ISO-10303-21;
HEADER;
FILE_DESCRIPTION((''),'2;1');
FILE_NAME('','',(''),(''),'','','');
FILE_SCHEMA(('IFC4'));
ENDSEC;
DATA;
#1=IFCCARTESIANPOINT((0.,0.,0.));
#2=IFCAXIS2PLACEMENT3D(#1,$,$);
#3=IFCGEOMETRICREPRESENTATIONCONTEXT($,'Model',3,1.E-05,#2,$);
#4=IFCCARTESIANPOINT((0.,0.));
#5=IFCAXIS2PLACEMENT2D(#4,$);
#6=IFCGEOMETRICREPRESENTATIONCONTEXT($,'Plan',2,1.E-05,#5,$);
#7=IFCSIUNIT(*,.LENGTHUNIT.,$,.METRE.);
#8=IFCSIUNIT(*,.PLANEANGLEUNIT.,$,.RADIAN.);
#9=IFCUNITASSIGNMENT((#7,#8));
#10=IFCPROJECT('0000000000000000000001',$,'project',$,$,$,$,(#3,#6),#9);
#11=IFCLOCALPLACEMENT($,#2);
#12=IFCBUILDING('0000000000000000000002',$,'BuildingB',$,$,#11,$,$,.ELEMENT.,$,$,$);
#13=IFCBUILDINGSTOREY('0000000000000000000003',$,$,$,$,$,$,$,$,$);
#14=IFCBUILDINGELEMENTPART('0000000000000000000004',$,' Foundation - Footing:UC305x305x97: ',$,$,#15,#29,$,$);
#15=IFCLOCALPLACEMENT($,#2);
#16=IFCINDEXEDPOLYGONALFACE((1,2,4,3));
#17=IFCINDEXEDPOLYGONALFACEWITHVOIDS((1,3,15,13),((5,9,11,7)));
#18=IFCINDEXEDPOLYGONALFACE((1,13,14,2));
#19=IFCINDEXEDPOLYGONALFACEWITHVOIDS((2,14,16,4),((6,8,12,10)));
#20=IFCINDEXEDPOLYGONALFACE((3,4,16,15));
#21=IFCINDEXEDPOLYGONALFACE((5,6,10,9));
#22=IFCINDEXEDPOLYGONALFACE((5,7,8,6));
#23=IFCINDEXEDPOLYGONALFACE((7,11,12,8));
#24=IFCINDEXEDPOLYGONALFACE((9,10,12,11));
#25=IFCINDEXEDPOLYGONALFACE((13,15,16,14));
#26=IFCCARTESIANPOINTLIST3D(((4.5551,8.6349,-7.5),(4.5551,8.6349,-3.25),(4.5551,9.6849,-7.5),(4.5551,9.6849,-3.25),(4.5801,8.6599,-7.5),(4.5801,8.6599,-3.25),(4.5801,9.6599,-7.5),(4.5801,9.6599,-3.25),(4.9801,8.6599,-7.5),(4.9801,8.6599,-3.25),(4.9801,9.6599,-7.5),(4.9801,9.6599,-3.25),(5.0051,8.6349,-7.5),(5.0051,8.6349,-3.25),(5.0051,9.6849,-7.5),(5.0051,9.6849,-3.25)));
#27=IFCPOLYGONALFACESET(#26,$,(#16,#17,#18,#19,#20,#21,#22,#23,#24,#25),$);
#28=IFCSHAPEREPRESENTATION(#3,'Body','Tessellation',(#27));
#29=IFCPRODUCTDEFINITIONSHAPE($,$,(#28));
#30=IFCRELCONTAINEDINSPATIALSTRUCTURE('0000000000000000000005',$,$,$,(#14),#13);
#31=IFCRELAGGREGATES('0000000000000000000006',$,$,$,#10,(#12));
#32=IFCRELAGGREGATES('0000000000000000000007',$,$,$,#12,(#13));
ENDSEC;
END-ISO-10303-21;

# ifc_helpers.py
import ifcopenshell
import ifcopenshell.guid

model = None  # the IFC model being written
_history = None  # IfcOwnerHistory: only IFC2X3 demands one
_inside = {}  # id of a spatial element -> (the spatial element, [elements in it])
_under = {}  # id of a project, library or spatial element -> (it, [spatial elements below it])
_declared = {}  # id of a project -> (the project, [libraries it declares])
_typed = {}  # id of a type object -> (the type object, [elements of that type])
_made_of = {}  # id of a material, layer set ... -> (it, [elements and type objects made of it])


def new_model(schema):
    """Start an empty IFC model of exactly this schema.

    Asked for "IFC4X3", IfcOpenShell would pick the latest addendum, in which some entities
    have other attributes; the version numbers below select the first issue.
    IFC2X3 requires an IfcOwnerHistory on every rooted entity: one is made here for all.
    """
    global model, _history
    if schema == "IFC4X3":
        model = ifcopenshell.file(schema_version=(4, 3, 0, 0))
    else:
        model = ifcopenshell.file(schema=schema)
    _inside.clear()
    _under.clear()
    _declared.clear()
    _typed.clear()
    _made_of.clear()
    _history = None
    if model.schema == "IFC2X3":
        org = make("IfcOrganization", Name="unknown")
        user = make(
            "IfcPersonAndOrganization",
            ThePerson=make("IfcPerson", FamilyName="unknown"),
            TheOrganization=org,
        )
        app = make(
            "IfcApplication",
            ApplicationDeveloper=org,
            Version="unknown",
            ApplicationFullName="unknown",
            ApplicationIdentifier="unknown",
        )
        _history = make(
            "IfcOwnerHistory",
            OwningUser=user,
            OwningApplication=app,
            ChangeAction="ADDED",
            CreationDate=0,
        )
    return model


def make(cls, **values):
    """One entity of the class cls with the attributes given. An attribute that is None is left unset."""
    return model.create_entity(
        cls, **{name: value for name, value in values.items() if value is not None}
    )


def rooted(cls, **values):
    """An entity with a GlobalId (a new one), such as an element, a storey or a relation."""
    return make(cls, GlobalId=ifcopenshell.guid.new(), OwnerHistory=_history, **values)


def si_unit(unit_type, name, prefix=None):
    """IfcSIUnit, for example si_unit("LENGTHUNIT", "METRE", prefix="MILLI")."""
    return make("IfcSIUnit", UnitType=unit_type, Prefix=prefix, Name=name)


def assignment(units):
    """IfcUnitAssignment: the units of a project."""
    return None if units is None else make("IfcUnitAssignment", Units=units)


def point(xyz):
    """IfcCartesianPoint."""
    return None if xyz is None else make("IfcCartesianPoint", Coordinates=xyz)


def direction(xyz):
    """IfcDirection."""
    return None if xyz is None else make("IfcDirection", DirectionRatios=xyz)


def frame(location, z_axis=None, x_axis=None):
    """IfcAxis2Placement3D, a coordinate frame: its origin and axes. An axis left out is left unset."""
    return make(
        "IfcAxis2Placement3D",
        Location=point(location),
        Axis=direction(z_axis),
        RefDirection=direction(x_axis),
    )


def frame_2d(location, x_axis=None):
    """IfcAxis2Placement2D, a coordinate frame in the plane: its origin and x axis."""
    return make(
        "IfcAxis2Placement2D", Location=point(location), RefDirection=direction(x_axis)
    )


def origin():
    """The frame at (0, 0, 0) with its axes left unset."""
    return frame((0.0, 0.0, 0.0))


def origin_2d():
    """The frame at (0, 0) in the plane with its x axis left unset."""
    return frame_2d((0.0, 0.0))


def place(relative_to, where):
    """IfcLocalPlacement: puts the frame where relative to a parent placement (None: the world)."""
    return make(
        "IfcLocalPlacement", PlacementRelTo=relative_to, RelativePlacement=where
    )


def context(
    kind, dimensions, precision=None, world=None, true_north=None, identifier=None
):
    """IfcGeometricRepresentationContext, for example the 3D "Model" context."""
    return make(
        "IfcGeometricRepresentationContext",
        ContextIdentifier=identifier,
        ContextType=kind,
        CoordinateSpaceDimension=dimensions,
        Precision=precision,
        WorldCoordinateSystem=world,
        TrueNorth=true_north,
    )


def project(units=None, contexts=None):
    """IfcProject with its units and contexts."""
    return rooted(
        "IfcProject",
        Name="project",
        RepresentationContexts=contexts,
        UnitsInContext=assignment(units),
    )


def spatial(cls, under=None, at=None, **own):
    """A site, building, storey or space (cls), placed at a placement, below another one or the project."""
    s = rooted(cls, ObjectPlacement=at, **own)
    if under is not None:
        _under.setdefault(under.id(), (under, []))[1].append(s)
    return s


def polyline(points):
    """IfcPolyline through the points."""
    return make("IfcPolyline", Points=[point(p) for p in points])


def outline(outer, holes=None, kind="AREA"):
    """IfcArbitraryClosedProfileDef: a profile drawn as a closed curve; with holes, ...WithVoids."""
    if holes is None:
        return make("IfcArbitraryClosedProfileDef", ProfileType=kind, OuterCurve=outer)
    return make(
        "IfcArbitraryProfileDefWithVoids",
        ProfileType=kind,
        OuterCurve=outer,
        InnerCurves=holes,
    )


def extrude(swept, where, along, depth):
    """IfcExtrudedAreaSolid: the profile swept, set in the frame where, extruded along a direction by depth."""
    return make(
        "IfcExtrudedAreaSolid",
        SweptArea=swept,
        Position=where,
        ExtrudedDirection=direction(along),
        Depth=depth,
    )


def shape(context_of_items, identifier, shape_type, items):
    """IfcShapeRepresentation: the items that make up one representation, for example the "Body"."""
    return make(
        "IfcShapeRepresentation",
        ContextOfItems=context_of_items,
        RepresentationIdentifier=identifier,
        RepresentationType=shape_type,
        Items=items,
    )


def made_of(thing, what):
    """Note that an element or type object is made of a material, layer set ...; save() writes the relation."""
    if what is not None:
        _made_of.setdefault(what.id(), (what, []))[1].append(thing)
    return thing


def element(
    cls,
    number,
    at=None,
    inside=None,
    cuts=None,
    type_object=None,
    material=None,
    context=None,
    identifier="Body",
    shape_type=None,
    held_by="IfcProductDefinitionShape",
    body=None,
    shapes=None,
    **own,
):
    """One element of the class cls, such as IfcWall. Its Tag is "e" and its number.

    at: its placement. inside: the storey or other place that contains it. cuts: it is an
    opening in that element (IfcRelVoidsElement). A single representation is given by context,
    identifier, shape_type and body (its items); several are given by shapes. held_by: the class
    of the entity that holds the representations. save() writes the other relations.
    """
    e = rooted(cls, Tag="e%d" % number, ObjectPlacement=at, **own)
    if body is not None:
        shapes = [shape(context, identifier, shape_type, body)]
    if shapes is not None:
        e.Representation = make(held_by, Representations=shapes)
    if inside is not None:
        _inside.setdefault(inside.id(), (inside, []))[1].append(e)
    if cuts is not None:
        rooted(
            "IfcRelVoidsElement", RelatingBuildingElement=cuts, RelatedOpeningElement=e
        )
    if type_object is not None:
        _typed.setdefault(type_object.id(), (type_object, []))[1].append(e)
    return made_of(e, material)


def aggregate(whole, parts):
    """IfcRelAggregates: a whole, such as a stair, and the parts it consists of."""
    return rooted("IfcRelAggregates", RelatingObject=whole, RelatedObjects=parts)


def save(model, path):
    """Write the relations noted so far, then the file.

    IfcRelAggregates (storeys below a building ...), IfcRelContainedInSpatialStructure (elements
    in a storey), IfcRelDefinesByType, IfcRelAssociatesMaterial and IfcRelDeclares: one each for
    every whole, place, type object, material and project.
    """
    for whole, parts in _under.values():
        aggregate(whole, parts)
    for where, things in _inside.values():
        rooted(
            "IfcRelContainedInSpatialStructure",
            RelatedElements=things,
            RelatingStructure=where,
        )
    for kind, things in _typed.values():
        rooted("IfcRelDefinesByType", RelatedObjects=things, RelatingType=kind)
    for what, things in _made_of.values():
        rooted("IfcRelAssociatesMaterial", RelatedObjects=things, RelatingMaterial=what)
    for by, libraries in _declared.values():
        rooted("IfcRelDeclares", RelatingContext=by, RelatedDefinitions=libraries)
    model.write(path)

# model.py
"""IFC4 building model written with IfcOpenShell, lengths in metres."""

from ifc_helpers import new_model, si_unit, origin, origin_2d, place, context, project, spatial, polyline, outline, extrude, element, save


model = new_model("IFC4")

# Units and contexts
model_context = context("Model", 3, precision=1e-05, world=origin())
plan_context = context("Plan", 2, precision=1e-05, world=origin_2d())
ifc_project = project(units=[si_unit("LENGTHUNIT", "METRE"), si_unit("PLANEANGLEUNIT", "RADIAN")], contexts=[model_context, plan_context])

# Building, storey
building_placement = place(None, origin())
building = spatial("IfcBuilding", under=ifc_project, at=building_placement, Name="BuildingB", CompositionType="ELEMENT")
storey = spatial("IfcBuildingStorey", under=building)

# Building element part, opening
building_element_part_1 = element("IfcBuildingElementPart", 1, inside=storey, Name=" Foundation - Footing:UC305x305x97: ", context=model_context, shape_type="SweptSolid", body=[
    extrude(outline(polyline([(4.5551, 8.6349, -7.5), (5.0051, 8.6349, -7.5), (5.0051, 9.6849, -7.5), (4.5551, 9.6849, -7.5), (4.5551, 8.6349, -7.5)])), None, (0.0, 0.0, 1.0), 4.25),
])
element("IfcOpeningElement", 2, inside=storey, cuts=building_element_part_1, context=model_context, shape_type="SweptSolid", body=[
    extrude(outline(polyline([(4.5801, 8.6599, -7.5), (4.9801, 8.6599, -7.5), (4.9801, 9.6599, -7.5), (4.5801, 9.6599, -7.5), (4.5801, 8.6599, -7.5)])), None, (0.0, 0.0, 1.0), 4.25),
])

save(model, "model.ifc")
